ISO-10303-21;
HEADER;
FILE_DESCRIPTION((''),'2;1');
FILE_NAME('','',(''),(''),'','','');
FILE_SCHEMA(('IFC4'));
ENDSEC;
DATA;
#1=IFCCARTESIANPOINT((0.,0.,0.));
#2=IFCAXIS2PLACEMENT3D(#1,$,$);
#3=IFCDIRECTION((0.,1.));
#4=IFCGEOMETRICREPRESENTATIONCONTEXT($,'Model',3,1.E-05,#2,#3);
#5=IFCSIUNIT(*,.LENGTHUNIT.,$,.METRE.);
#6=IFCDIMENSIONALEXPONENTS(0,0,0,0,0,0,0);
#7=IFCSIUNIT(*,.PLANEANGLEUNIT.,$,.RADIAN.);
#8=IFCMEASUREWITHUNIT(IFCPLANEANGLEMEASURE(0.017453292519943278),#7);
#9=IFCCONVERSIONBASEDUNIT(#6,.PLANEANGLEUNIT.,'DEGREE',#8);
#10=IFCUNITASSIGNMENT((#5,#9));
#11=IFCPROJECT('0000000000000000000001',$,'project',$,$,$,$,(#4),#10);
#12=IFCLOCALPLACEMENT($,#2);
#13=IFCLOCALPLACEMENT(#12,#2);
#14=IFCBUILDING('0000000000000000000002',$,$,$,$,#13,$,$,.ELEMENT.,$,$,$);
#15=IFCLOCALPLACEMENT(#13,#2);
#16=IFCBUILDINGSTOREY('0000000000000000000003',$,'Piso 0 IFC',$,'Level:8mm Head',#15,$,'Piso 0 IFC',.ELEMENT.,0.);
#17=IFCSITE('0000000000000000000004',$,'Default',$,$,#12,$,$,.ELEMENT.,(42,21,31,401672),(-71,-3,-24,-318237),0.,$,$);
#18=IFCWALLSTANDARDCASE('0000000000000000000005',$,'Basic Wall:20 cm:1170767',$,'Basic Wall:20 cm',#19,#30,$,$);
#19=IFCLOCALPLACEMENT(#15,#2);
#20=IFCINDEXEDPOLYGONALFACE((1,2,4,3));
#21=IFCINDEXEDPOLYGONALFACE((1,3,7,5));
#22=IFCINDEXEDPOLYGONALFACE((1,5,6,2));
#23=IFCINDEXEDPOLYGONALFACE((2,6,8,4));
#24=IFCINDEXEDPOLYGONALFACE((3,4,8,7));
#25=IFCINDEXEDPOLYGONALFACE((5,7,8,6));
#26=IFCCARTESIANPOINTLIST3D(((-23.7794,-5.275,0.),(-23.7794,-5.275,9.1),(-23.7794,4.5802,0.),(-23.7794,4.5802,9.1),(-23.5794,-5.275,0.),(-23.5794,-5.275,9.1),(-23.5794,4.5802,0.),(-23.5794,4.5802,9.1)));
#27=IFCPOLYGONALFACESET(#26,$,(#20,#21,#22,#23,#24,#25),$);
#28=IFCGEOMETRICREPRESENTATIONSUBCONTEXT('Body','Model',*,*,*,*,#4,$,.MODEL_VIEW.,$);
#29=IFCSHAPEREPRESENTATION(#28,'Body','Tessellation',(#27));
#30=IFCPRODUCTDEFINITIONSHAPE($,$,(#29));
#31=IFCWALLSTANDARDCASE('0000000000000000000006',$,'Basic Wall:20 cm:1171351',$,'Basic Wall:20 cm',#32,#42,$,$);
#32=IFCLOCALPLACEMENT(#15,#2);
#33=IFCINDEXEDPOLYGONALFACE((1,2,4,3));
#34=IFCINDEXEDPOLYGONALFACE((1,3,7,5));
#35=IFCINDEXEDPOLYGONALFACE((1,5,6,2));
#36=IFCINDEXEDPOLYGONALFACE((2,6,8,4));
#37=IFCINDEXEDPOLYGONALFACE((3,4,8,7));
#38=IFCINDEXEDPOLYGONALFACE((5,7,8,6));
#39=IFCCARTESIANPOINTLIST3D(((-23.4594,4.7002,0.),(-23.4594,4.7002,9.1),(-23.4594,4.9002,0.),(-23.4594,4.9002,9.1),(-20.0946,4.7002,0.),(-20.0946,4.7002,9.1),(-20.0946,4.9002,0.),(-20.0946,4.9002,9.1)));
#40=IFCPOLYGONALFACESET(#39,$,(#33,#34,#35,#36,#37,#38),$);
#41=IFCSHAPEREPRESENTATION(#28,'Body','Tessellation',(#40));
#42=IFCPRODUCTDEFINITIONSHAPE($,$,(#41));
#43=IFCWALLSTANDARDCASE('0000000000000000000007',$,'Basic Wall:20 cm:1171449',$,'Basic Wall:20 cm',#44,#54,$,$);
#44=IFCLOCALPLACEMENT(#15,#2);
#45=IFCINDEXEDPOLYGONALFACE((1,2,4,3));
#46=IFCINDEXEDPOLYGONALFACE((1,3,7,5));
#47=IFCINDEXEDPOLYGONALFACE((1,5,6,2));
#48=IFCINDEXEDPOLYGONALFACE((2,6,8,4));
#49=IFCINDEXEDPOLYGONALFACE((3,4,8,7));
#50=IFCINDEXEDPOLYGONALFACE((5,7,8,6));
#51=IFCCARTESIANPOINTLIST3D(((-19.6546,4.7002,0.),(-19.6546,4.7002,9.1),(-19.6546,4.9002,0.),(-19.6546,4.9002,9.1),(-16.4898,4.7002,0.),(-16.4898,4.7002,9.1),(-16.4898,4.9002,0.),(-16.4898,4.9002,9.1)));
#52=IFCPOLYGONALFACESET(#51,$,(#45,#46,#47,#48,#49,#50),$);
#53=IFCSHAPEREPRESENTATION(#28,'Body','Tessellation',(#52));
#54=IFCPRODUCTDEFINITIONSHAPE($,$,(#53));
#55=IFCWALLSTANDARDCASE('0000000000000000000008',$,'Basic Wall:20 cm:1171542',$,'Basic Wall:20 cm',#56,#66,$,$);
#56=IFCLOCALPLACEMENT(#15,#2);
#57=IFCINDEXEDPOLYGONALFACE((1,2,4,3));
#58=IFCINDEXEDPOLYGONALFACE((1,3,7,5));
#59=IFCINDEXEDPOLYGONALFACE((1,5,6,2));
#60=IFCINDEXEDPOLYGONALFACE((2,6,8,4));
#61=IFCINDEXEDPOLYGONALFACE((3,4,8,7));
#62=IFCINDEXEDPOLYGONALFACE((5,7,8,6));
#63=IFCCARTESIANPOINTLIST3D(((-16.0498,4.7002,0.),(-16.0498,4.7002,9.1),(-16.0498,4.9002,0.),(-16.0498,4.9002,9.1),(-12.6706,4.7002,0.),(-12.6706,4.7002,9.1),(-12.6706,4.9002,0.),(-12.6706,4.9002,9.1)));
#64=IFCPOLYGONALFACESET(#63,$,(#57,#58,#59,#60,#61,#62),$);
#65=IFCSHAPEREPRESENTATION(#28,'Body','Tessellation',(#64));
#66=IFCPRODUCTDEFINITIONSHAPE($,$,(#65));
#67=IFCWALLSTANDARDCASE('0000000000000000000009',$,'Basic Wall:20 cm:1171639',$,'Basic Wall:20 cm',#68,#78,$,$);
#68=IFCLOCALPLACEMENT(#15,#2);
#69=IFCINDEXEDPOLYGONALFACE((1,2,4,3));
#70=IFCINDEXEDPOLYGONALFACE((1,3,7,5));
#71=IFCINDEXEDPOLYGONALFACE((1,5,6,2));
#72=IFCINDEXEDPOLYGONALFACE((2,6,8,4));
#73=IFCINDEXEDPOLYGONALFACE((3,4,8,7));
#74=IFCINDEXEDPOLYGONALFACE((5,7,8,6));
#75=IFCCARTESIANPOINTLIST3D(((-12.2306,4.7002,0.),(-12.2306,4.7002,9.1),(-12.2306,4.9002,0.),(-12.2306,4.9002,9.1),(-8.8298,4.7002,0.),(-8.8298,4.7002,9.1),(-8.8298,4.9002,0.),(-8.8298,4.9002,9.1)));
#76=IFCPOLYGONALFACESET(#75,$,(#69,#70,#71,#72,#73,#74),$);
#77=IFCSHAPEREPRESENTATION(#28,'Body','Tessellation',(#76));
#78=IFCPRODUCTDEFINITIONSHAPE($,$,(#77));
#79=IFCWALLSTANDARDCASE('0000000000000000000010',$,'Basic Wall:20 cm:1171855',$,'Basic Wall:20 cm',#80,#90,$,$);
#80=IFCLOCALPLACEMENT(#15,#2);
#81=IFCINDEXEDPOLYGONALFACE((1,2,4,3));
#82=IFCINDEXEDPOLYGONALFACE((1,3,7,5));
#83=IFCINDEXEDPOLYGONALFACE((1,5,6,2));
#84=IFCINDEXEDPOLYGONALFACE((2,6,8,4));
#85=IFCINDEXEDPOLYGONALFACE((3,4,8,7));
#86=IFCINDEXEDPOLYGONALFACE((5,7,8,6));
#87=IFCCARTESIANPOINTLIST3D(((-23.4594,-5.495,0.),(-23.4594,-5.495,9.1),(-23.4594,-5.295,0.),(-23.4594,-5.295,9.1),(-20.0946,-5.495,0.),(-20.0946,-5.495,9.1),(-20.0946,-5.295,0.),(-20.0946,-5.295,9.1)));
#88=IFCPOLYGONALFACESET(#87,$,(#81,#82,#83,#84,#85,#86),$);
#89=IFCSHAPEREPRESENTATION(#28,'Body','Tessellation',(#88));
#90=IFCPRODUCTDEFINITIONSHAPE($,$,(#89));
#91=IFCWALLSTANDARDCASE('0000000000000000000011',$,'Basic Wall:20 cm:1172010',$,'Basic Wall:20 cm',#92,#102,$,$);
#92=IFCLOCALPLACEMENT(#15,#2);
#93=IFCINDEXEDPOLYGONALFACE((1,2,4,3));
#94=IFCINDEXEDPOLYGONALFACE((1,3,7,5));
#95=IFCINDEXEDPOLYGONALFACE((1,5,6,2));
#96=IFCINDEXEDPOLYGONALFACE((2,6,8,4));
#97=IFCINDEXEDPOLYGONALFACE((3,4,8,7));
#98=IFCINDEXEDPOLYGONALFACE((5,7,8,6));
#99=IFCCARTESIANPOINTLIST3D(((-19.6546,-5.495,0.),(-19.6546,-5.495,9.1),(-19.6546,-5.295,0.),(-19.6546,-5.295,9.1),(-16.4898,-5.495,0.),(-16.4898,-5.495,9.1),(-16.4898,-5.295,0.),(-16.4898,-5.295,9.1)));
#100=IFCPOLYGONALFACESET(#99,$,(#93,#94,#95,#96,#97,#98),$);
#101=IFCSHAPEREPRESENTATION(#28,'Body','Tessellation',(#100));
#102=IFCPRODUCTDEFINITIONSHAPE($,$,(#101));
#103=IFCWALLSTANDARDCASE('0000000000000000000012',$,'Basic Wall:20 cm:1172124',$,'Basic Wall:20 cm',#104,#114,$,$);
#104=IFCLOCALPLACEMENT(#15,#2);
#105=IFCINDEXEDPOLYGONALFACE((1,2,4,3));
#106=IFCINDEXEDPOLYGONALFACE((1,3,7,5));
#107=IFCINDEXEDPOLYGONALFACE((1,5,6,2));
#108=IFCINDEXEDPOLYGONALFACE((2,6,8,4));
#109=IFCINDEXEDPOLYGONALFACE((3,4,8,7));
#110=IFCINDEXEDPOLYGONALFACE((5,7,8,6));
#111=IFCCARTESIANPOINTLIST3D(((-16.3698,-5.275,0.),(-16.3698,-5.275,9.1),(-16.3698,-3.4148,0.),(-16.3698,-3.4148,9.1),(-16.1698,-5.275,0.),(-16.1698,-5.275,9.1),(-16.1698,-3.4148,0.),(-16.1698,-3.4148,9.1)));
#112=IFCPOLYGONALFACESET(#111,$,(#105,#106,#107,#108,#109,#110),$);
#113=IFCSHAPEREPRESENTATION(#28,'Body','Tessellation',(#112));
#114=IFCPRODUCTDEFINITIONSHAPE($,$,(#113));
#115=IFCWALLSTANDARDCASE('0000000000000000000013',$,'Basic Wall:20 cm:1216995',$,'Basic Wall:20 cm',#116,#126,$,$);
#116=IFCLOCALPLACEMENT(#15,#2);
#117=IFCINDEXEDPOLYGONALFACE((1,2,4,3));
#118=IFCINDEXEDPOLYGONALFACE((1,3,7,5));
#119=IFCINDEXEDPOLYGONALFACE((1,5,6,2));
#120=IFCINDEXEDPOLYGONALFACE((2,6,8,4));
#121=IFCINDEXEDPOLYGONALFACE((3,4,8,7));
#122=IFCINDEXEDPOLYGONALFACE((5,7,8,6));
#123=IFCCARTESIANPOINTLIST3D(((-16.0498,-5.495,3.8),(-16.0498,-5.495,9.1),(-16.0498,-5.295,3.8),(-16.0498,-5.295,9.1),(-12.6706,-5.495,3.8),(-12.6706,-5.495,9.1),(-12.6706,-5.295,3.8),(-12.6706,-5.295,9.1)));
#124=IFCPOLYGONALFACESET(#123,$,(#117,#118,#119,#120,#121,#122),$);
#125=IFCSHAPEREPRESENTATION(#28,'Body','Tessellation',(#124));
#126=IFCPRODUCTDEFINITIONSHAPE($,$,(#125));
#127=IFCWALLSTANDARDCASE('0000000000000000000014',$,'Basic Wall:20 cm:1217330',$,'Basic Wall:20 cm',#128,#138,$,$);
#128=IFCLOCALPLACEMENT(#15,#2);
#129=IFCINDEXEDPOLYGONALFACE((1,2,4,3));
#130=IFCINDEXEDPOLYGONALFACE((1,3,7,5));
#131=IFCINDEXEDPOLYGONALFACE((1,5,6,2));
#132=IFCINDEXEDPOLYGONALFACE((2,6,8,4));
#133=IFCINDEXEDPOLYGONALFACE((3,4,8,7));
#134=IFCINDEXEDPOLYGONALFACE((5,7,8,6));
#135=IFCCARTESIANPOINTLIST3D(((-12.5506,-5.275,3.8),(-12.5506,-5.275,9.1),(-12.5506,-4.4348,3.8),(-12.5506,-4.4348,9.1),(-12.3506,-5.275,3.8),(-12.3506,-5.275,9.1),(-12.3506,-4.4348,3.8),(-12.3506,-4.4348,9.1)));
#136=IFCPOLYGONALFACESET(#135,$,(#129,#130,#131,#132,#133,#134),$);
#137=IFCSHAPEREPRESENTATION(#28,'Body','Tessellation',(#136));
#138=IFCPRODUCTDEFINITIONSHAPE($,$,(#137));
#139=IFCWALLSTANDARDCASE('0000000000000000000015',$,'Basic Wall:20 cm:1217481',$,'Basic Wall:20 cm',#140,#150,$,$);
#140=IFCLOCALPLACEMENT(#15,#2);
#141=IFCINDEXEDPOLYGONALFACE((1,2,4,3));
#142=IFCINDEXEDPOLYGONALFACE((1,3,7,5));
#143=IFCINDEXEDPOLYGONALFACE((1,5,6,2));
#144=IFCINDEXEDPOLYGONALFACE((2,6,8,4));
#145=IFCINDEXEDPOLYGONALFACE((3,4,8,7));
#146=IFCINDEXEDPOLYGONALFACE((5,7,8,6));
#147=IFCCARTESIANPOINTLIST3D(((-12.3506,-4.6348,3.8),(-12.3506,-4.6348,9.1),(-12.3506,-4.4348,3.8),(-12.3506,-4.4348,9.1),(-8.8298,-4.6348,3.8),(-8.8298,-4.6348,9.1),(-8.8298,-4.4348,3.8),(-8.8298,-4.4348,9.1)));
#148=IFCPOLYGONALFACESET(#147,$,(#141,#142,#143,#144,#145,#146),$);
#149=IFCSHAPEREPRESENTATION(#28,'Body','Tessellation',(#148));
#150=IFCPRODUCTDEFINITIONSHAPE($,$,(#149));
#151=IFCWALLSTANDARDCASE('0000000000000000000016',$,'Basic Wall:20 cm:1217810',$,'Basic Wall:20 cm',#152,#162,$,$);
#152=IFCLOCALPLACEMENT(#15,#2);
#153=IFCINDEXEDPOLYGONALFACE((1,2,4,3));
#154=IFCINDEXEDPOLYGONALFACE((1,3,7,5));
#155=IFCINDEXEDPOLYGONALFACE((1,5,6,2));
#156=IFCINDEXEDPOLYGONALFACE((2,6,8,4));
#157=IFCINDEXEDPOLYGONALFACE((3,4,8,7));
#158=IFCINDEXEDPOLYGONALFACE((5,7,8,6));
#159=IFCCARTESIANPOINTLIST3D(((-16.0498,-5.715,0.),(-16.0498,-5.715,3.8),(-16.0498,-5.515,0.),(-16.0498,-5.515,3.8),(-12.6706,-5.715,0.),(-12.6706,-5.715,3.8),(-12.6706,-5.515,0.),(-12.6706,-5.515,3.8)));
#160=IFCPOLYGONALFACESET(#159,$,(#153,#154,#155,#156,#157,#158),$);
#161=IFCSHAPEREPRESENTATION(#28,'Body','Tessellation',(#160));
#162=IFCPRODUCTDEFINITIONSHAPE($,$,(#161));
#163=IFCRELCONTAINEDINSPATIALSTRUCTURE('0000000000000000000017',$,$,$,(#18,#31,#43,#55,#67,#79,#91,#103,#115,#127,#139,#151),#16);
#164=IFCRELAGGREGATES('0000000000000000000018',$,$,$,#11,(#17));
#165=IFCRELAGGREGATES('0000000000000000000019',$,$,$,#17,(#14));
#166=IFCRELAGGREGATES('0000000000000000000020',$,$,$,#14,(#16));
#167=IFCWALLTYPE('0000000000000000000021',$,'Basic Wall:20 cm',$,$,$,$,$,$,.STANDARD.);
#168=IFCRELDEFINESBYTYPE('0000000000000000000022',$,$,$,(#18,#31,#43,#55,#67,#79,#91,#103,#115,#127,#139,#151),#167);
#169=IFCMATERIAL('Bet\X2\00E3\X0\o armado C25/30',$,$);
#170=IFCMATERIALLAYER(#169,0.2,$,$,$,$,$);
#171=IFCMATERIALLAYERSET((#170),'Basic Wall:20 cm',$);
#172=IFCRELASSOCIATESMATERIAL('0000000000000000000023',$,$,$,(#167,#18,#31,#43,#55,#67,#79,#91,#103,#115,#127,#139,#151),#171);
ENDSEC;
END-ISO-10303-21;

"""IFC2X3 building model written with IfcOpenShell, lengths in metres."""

from ifc_helpers import new_model, entity, si_unit, converted_unit, direction, frame, frame_2d, origin, place, context, subcontext, project, spatial, polyline, rectangle, extrude, clip, bounded_halfspace, material, layer, layer_set, layer_usage, type_object, element, save


model = new_model("IFC2X3")

# Units and contexts
model_context = context("Model", 3, precision=1e-05, world=origin(), true_north=direction((0.0, 1.0)))
body_context = subcontext(model_context, "Body", "Model", "MODEL_VIEW")
ifc_project = project(units=[si_unit("LENGTHUNIT", "METRE"), converted_unit("PLANEANGLEUNIT", "DEGREE", entity("IfcPlaneAngleMeasure", 0.017453292519943278), si_unit("PLANEANGLEUNIT", "RADIAN"), dimensions=[0, 0, 0, 0, 0, 0, 0])], contexts=[model_context])

# Site, building, storey
site_placement = place(None, origin())
site = spatial("IfcSite", under=ifc_project, at=site_placement, Name="Default", CompositionType="ELEMENT", RefLatitude=(42, 21, 31, 401672), RefLongitude=(-71, -3, -24, -318237), RefElevation=0.0)
building_placement = place(site_placement, origin())
building = spatial("IfcBuilding", under=site, at=building_placement, CompositionType="ELEMENT")
storey_placement = place(building_placement, origin())
storey = spatial("IfcBuildingStorey", under=building, at=storey_placement, Name="Piso 0 IFC", ObjectType="Level:8mm Head", LongName="Piso 0 IFC", CompositionType="ELEMENT", Elevation=0.0)

# Walls
ifc_material_1 = material(Name="Betão armado C25/30")
ifc_layer_1 = layer(ifc_material_1, 0.2)
ifc_layer_set_1 = layer_set([ifc_layer_1], Name="Basic Wall:20 cm")
ifc_layer_usage_1 = layer_usage(ifc_layer_set_1, "AXIS2", "NEGATIVE", 0.1)
wall_type_1 = type_object("IfcWallType", Name="Basic Wall:20 cm", PredefinedType="STANDARD", material=ifc_layer_set_1)
wall_1_placement = place(storey_placement, frame((-23.6794, -5.275, 0.0), z_axis=(0.0, 0.0, 1.0), x_axis=(0.0, 1.0, 0.0)))
element("IfcWallStandardCase", 1, at=wall_1_placement, inside=storey, type_object=wall_type_1, material=ifc_layer_usage_1, Name="Basic Wall:20 cm:1170767", ObjectType="Basic Wall:20 cm", context=body_context, shape_type="Clipping", body=[
    clip(extrude(rectangle(XDim=9.8552, YDim=0.2, at=frame_2d((4.9276, 0.0), x_axis=(-1.0, 0.0))), origin(), (0.0, 0.0, 1.0), 9.1), bounded_halfspace(frame((0.0, -0.1, 9.1), z_axis=(0.0, 0.0, -1.0), x_axis=(0.0, 1.0, 0.0)), True, frame((0.0, -0.1, 9.1)), polyline([(0.0, 0.0), (9.8552, 0.0), (9.8552, 0.2), (0.0, 0.2), (0.0, 0.0)]))),
])
ifc_layer_usage_2 = layer_usage(ifc_layer_set_1, "AXIS2", "NEGATIVE", 0.1)
wall_2_placement = place(storey_placement, frame((-23.4594, 4.8002, 0.0)))
element("IfcWallStandardCase", 2, at=wall_2_placement, inside=storey, type_object=wall_type_1, material=ifc_layer_usage_2, Name="Basic Wall:20 cm:1171351", ObjectType="Basic Wall:20 cm", context=body_context, shape_type="Clipping", body=[
    clip(extrude(rectangle(XDim=3.3648, YDim=0.2, at=frame_2d((1.6824, 0.0), x_axis=(-1.0, 0.0))), origin(), (0.0, 0.0, 1.0), 9.1), bounded_halfspace(frame((0.0, -0.1, 9.1), z_axis=(0.0, 0.0, -1.0), x_axis=(-1.0, 0.0, 0.0)), True, frame((0.0, -0.1, 9.1)), polyline([(0.0, 0.0), (3.3648, 0.0), (3.3648, 0.2), (0.0, 0.2), (0.0, 0.0)]))),
])
ifc_layer_usage_3 = layer_usage(ifc_layer_set_1, "AXIS2", "NEGATIVE", 0.1)
wall_3_placement = place(storey_placement, frame((-19.6546, 4.8002, 0.0)))
element("IfcWallStandardCase", 3, at=wall_3_placement, inside=storey, type_object=wall_type_1, material=ifc_layer_usage_3, Name="Basic Wall:20 cm:1171449", ObjectType="Basic Wall:20 cm", context=body_context, shape_type="Clipping", body=[
    clip(extrude(rectangle(XDim=3.1648, YDim=0.2, at=frame_2d((1.5824, 0.0), x_axis=(-1.0, 0.0))), origin(), (0.0, 0.0, 1.0), 9.1), bounded_halfspace(frame((0.0, -0.1, 9.1), z_axis=(0.0, 0.0, -1.0), x_axis=(-1.0, 0.0, 0.0)), True, frame((0.0, -0.1, 9.1)), polyline([(0.0, 0.0), (3.1648, 0.0), (3.1648, 0.2), (0.0, 0.2), (0.0, 0.0)]))),
])
ifc_layer_usage_4 = layer_usage(ifc_layer_set_1, "AXIS2", "NEGATIVE", 0.1)
wall_4_placement = place(storey_placement, frame((-16.0498, 4.8002, 0.0)))
element("IfcWallStandardCase", 4, at=wall_4_placement, inside=storey, type_object=wall_type_1, material=ifc_layer_usage_4, Name="Basic Wall:20 cm:1171542", ObjectType="Basic Wall:20 cm", context=body_context, shape_type="Clipping", body=[
    clip(extrude(rectangle(XDim=3.3792, YDim=0.2, at=frame_2d((1.6896, 0.0), x_axis=(-1.0, 0.0))), origin(), (0.0, 0.0, 1.0), 9.1), bounded_halfspace(frame((0.0, -0.1, 9.1), z_axis=(0.0, 0.0, -1.0), x_axis=(-1.0, 0.0, 0.0)), True, frame((0.0, -0.1, 9.1)), polyline([(0.0, 0.0), (3.3792, 0.0), (3.3792, 0.2), (0.0, 0.2), (0.0, 0.0)]))),
])
ifc_layer_usage_5 = layer_usage(ifc_layer_set_1, "AXIS2", "NEGATIVE", 0.1)
wall_5_placement = place(storey_placement, frame((-12.2306, 4.8002, 0.0)))
element("IfcWallStandardCase", 5, at=wall_5_placement, inside=storey, type_object=wall_type_1, material=ifc_layer_usage_5, Name="Basic Wall:20 cm:1171639", ObjectType="Basic Wall:20 cm", context=body_context, shape_type="Clipping", body=[
    clip(extrude(rectangle(XDim=3.4008, YDim=0.2, at=frame_2d((1.7004, 0.0), x_axis=(-1.0, 0.0))), origin(), (0.0, 0.0, 1.0), 9.1), bounded_halfspace(frame((0.0, -0.1, 9.1), z_axis=(0.0, 0.0, -1.0), x_axis=(-1.0, 0.0, 0.0)), True, frame((0.0, -0.1, 9.1)), polyline([(0.0, 0.0), (3.4008, 0.0), (3.4008, 0.2), (0.0, 0.2), (0.0, 0.0)]))),
])
ifc_layer_usage_6 = layer_usage(ifc_layer_set_1, "AXIS2", "NEGATIVE", 0.1)
wall_6_placement = place(storey_placement, frame((-23.4594, -5.395, 0.0)))
element("IfcWallStandardCase", 6, at=wall_6_placement, inside=storey, type_object=wall_type_1, material=ifc_layer_usage_6, Name="Basic Wall:20 cm:1171855", ObjectType="Basic Wall:20 cm", context=body_context, shape_type="Clipping", body=[
    clip(extrude(rectangle(XDim=3.3648, YDim=0.2, at=frame_2d((1.6824, 0.0), x_axis=(-1.0, 0.0))), origin(), (0.0, 0.0, 1.0), 9.1), bounded_halfspace(frame((0.0, -0.1, 9.1), z_axis=(0.0, 0.0, -1.0), x_axis=(-1.0, 0.0, 0.0)), True, frame((0.0, -0.1, 9.1)), polyline([(0.0, 0.0), (3.3648, 0.0), (3.3648, 0.2), (0.0, 0.2), (0.0, 0.0)]))),
])
ifc_layer_usage_7 = layer_usage(ifc_layer_set_1, "AXIS2", "NEGATIVE", 0.1)
wall_7_placement = place(storey_placement, frame((-19.6546, -5.395, 0.0)))
element("IfcWallStandardCase", 7, at=wall_7_placement, inside=storey, type_object=wall_type_1, material=ifc_layer_usage_7, Name="Basic Wall:20 cm:1172010", ObjectType="Basic Wall:20 cm", context=body_context, shape_type="Clipping", body=[
    clip(extrude(rectangle(XDim=3.1648, YDim=0.2, at=frame_2d((1.5824, 0.0), x_axis=(-1.0, 0.0))), origin(), (0.0, 0.0, 1.0), 9.1), bounded_halfspace(frame((0.0, -0.1, 9.1), z_axis=(0.0, 0.0, -1.0), x_axis=(-1.0, 0.0, 0.0)), True, frame((0.0, -0.1, 9.1)), polyline([(0.0, 0.0), (3.1648, 0.0), (3.1648, 0.2), (0.0, 0.2), (0.0, 0.0)]))),
])
ifc_layer_usage_8 = layer_usage(ifc_layer_set_1, "AXIS2", "NEGATIVE", 0.1)
wall_8_placement = place(storey_placement, frame((-16.2698, -5.275, 0.0), z_axis=(0.0, 0.0, 1.0), x_axis=(0.0, 1.0, 0.0)))
element("IfcWallStandardCase", 8, at=wall_8_placement, inside=storey, type_object=wall_type_1, material=ifc_layer_usage_8, Name="Basic Wall:20 cm:1172124", ObjectType="Basic Wall:20 cm", context=body_context, shape_type="Clipping", body=[
    clip(extrude(rectangle(XDim=1.8602, YDim=0.2, at=frame_2d((0.9301, 0.0), x_axis=(-1.0, 0.0))), origin(), (0.0, 0.0, 1.0), 9.1), bounded_halfspace(frame((0.0, -0.1, 9.1), z_axis=(0.0, 0.0, -1.0), x_axis=(0.0, 1.0, 0.0)), True, frame((0.0, -0.1, 9.1)), polyline([(0.0, 0.0), (1.8602, 0.0), (1.8602, 0.2), (0.0, 0.2), (0.0, 0.0)]))),
])
ifc_layer_usage_9 = layer_usage(ifc_layer_set_1, "AXIS2", "NEGATIVE", 0.1)
wall_9_placement = place(storey_placement, frame((-16.0498, -5.395, 3.8)))
element("IfcWallStandardCase", 9, at=wall_9_placement, inside=storey, type_object=wall_type_1, material=ifc_layer_usage_9, Name="Basic Wall:20 cm:1216995", ObjectType="Basic Wall:20 cm", context=body_context, shape_type="Clipping", body=[
    clip(extrude(rectangle(XDim=3.3792, YDim=0.2, at=frame_2d((1.6896, 0.0), x_axis=(-1.0, 0.0))), origin(), (0.0, 0.0, 1.0), 5.3), bounded_halfspace(frame((0.0, -0.1, 5.3), z_axis=(0.0, 0.0, -1.0), x_axis=(-1.0, 0.0, 0.0)), True, frame((0.0, -0.1, 5.3)), polyline([(0.0, 0.0), (3.3792, 0.0), (3.3792, 0.2), (0.0, 0.2), (0.0, 0.0)]))),
])
ifc_layer_usage_10 = layer_usage(ifc_layer_set_1, "AXIS2", "NEGATIVE", 0.1)
wall_10_placement = place(storey_placement, frame((-12.4506, -5.275, 3.8), z_axis=(0.0, 0.0, 1.0), x_axis=(0.0, 1.0, 0.0)))
element("IfcWallStandardCase", 10, at=wall_10_placement, inside=storey, type_object=wall_type_1, material=ifc_layer_usage_10, Name="Basic Wall:20 cm:1217330", ObjectType="Basic Wall:20 cm", context=body_context, shape_type="Clipping", body=[
    clip(extrude(rectangle(XDim=0.8402, YDim=0.2, at=frame_2d((0.4201, 0.0), x_axis=(-1.0, 0.0))), origin(), (0.0, 0.0, 1.0), 5.3), bounded_halfspace(frame((0.0, -0.1, 5.3), z_axis=(0.0, 0.0, -1.0), x_axis=(0.0, 1.0, 0.0)), True, frame((0.0, -0.1, 5.3)), polyline([(0.0, 0.0), (0.6402, 0.0), (0.8402, 0.0), (0.8402, 0.2), (0.0, 0.2), (0.0, 0.0)]))),
])
ifc_layer_usage_11 = layer_usage(ifc_layer_set_1, "AXIS2", "NEGATIVE", 0.1)
wall_11_placement = place(storey_placement, frame((-12.3506, -4.5348, 3.8)))
element("IfcWallStandardCase", 11, at=wall_11_placement, inside=storey, type_object=wall_type_1, material=ifc_layer_usage_11, Name="Basic Wall:20 cm:1217481", ObjectType="Basic Wall:20 cm", context=body_context, shape_type="Clipping", body=[
    clip(extrude(rectangle(XDim=3.5208, YDim=0.2, at=frame_2d((1.7604, 0.0), x_axis=(-1.0, 0.0))), origin(), (0.0, 0.0, 1.0), 5.3), bounded_halfspace(frame((0.0, -0.1, 5.3), z_axis=(0.0, 0.0, -1.0), x_axis=(-1.0, 0.0, 0.0)), True, frame((0.0, -0.1, 5.3)), polyline([(0.0, 0.0), (3.5208, 0.0), (3.5208, 0.2), (0.0, 0.2), (0.0, 0.0)]))),
])
ifc_layer_usage_12 = layer_usage(ifc_layer_set_1, "AXIS2", "NEGATIVE", 0.1)
wall_12_placement = place(storey_placement, frame((-16.0498, -5.615, 0.0)))
element("IfcWallStandardCase", 12, at=wall_12_placement, inside=storey, type_object=wall_type_1, material=ifc_layer_usage_12, Name="Basic Wall:20 cm:1217810", ObjectType="Basic Wall:20 cm", context=body_context, shape_type="SweptSolid", body=[
    extrude(rectangle(XDim=3.3792, YDim=0.2, at=frame_2d((1.6896, 0.0), x_axis=(-1.0, 0.0))), origin(), (0.0, 0.0, 1.0), 3.8),
])

save(model, "model.ifc")
